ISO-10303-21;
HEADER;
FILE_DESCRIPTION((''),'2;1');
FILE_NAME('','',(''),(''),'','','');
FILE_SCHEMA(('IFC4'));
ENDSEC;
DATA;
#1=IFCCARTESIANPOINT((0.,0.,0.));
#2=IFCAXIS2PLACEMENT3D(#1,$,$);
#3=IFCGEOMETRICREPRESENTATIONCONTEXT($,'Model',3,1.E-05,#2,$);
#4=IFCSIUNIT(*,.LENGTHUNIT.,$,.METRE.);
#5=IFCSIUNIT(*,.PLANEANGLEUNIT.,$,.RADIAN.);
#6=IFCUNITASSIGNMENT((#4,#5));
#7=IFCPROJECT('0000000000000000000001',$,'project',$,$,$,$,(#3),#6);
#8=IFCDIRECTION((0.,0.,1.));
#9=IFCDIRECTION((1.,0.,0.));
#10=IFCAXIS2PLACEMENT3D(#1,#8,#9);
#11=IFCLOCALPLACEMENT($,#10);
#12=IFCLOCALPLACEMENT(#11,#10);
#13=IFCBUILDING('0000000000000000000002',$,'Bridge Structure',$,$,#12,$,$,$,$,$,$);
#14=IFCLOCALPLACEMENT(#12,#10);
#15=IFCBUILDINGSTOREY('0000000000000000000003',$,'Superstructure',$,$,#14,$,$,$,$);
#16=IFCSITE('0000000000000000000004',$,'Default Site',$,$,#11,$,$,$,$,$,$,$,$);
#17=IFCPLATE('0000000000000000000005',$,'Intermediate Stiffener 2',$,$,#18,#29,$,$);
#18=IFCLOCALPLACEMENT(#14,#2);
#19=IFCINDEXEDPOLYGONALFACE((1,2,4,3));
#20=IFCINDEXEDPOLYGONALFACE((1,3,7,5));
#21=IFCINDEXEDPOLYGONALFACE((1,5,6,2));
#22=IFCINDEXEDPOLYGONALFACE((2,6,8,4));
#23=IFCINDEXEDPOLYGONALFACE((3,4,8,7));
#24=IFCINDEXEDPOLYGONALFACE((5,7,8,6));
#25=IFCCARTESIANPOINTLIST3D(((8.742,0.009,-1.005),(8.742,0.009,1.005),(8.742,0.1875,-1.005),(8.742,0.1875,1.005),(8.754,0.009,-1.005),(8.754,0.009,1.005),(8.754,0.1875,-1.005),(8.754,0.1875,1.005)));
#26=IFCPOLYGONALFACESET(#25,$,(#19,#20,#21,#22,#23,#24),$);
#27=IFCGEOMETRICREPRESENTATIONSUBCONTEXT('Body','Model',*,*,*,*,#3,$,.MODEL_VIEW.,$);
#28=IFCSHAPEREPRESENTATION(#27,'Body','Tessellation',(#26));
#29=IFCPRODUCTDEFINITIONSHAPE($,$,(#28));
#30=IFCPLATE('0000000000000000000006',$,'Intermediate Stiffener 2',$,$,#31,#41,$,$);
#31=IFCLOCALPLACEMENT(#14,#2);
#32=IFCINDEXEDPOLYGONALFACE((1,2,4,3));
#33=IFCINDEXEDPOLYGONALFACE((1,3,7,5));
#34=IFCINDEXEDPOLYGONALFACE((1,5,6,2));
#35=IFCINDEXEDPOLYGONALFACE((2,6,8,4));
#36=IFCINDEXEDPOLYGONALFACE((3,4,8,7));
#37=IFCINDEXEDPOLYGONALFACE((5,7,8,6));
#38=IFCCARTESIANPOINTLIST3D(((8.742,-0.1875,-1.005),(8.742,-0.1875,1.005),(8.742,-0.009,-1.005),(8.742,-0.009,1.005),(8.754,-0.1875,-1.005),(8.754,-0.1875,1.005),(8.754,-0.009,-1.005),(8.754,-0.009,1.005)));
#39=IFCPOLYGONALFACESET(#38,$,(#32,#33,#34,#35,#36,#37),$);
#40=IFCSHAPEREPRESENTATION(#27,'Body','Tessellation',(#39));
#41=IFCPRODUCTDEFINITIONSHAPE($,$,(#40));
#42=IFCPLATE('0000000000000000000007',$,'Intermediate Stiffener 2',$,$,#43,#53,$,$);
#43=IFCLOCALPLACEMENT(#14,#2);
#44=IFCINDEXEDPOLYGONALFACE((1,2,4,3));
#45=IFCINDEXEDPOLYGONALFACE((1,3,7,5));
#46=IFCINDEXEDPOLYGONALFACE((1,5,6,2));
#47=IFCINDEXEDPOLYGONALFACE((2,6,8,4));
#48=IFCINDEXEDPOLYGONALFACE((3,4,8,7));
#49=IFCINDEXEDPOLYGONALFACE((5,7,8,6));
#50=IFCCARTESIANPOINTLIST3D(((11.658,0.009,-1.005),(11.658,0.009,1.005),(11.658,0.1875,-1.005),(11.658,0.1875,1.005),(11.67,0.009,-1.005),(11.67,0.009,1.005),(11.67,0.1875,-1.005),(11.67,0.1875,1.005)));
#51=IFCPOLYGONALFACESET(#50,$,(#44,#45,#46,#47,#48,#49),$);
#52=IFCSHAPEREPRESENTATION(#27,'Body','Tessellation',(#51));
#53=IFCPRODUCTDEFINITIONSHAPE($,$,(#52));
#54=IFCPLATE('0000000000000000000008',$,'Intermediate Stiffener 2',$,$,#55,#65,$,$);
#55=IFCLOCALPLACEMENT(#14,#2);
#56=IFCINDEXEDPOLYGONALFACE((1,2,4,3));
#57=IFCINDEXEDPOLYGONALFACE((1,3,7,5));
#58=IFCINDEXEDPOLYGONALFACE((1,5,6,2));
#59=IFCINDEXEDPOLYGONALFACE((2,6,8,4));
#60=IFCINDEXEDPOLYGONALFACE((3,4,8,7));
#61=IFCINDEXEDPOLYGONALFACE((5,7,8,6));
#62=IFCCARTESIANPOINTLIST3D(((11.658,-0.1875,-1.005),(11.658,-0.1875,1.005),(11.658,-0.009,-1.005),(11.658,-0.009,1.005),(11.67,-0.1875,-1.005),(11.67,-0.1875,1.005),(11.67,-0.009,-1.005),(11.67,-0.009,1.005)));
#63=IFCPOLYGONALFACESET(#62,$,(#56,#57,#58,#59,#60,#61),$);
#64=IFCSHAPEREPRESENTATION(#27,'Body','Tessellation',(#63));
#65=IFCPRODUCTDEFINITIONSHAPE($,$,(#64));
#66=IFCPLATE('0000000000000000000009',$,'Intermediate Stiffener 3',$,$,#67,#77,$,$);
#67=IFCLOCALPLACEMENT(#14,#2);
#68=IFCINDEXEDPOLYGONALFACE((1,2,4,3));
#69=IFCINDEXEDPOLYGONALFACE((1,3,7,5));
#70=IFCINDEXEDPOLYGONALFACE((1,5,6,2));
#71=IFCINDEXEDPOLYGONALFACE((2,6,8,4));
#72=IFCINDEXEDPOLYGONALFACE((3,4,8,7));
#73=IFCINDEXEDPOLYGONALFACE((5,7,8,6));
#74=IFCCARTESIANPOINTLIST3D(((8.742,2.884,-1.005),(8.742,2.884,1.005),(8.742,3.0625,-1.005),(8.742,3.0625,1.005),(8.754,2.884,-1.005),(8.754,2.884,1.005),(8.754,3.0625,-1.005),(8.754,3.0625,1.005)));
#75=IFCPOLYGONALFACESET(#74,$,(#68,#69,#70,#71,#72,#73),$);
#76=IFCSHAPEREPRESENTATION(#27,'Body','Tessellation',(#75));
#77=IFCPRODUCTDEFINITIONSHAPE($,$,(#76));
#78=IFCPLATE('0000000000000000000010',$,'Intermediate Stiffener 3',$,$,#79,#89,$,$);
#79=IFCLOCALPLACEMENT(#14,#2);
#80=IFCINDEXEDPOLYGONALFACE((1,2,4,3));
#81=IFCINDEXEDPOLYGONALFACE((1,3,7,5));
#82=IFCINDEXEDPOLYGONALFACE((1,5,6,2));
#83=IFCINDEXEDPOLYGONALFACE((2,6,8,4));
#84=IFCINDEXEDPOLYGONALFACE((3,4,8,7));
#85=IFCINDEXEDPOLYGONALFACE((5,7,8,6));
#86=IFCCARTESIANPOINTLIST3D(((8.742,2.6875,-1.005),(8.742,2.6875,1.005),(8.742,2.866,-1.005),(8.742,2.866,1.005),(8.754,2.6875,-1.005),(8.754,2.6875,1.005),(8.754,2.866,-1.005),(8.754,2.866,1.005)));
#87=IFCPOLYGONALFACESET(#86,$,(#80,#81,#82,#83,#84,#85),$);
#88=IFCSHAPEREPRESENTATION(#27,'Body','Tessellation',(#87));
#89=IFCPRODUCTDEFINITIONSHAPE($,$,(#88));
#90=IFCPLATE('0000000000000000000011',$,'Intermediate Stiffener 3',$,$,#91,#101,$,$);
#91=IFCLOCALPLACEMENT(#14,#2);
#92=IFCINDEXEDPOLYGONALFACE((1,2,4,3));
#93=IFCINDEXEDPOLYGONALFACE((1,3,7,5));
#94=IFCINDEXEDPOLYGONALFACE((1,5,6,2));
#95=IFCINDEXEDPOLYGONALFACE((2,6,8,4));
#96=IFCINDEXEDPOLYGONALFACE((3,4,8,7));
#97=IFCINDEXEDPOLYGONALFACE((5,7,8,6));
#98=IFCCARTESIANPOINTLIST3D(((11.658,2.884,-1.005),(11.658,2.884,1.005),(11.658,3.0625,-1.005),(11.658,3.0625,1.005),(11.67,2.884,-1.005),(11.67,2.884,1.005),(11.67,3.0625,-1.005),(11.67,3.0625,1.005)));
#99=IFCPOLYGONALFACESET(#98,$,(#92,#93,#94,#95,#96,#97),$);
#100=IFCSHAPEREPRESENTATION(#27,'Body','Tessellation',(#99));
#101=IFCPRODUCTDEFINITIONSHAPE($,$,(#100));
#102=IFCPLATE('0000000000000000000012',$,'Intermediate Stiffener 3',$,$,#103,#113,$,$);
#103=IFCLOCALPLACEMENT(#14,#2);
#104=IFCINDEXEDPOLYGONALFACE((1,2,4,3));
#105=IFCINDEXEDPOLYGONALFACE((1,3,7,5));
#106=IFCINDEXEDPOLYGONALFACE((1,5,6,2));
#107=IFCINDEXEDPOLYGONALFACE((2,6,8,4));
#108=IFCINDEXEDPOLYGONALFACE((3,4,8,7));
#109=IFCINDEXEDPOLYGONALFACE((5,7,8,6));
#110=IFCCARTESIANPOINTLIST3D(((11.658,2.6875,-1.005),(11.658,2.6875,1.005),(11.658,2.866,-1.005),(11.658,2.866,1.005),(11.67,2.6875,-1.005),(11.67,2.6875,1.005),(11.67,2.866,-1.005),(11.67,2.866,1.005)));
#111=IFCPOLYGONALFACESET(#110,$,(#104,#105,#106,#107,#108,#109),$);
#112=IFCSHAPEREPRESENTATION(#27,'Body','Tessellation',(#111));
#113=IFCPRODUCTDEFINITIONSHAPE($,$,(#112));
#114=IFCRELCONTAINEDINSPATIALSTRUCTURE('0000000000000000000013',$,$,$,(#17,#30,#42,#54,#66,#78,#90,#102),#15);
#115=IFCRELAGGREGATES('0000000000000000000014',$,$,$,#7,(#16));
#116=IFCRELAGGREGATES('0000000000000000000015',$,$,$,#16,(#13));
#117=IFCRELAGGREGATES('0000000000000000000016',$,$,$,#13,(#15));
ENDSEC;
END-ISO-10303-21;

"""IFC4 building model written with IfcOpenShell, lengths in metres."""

from ifc_helpers import new_model, si_unit, frame, origin, origin_with_axes, origin_2d_with_axis, place, context, subcontext, project, spatial, rectangle, extrude, element, save


model = new_model("IFC4")

# Units and contexts
model_context = context("Model", 3, precision=1e-05, world=origin())
body_context = subcontext(model_context, "Body", "Model", "MODEL_VIEW")
ifc_project = project(units=[si_unit("LENGTHUNIT", "METRE"), si_unit("PLANEANGLEUNIT", "RADIAN")], contexts=[model_context])

# Site, building, storey
site_placement = place(None, origin_with_axes())
site = spatial("IfcSite", under=ifc_project, at=site_placement, Name="Default Site")
building_placement = place(site_placement, origin_with_axes())
building = spatial("IfcBuilding", under=site, at=building_placement, Name="Bridge Structure")
storey_placement = place(building_placement, origin_with_axes())
storey = spatial("IfcBuildingStorey", under=building, at=storey_placement, Name="Superstructure")

# Plates
for number, where, z_axis, x_axis, name in (
    (1, (8.748, 0.0983, -1.005), (0.0, 0.0, 1.0), (1.0, 0.0, 0.0), "Intermediate Stiffener 2"),
    (2, (8.748, -0.0983, -1.005), (0.0, 0.0, 1.0), (1.0, 0.0, 0.0), "Intermediate Stiffener 2"),
    (3, (11.664, 0.0983, -1.005), (0.0, 0.0, 1.0), (1.0, 0.0, 0.0), "Intermediate Stiffener 2"),
    (4, (11.664, -0.0983, -1.005), (0.0, 0.0, 1.0), (1.0, 0.0, 0.0), "Intermediate Stiffener 2"),
    (5, (8.748, 2.9733, -1.005), (0.0, 0.0, 1.0), (1.0, 0.0, 0.0), "Intermediate Stiffener 3"),
    (6, (8.748, 2.7768, -1.005), (0.0, 0.0, 1.0), (1.0, 0.0, 0.0), "Intermediate Stiffener 3"),
    (7, (11.664, 2.9733, -1.005), (0.0, 0.0, 1.0), (1.0, 0.0, 0.0), "Intermediate Stiffener 3"),
    (8, (11.664, 2.7768, -1.005), (0.0, 0.0, 1.0), (1.0, 0.0, 0.0), "Intermediate Stiffener 3"),
):
    element("IfcPlate", number, at=place(storey_placement, frame(where, z_axis=z_axis, x_axis=x_axis)), inside=storey, Name=name, context=body_context, shape_type="SweptSolid", body=[
        extrude(rectangle(XDim=0.012, YDim=0.1785, at=origin_2d_with_axis()), origin_with_axes(), (0.0, 0.0, 1.0), 2.01),
    ])

save(model, "model.ifc")
